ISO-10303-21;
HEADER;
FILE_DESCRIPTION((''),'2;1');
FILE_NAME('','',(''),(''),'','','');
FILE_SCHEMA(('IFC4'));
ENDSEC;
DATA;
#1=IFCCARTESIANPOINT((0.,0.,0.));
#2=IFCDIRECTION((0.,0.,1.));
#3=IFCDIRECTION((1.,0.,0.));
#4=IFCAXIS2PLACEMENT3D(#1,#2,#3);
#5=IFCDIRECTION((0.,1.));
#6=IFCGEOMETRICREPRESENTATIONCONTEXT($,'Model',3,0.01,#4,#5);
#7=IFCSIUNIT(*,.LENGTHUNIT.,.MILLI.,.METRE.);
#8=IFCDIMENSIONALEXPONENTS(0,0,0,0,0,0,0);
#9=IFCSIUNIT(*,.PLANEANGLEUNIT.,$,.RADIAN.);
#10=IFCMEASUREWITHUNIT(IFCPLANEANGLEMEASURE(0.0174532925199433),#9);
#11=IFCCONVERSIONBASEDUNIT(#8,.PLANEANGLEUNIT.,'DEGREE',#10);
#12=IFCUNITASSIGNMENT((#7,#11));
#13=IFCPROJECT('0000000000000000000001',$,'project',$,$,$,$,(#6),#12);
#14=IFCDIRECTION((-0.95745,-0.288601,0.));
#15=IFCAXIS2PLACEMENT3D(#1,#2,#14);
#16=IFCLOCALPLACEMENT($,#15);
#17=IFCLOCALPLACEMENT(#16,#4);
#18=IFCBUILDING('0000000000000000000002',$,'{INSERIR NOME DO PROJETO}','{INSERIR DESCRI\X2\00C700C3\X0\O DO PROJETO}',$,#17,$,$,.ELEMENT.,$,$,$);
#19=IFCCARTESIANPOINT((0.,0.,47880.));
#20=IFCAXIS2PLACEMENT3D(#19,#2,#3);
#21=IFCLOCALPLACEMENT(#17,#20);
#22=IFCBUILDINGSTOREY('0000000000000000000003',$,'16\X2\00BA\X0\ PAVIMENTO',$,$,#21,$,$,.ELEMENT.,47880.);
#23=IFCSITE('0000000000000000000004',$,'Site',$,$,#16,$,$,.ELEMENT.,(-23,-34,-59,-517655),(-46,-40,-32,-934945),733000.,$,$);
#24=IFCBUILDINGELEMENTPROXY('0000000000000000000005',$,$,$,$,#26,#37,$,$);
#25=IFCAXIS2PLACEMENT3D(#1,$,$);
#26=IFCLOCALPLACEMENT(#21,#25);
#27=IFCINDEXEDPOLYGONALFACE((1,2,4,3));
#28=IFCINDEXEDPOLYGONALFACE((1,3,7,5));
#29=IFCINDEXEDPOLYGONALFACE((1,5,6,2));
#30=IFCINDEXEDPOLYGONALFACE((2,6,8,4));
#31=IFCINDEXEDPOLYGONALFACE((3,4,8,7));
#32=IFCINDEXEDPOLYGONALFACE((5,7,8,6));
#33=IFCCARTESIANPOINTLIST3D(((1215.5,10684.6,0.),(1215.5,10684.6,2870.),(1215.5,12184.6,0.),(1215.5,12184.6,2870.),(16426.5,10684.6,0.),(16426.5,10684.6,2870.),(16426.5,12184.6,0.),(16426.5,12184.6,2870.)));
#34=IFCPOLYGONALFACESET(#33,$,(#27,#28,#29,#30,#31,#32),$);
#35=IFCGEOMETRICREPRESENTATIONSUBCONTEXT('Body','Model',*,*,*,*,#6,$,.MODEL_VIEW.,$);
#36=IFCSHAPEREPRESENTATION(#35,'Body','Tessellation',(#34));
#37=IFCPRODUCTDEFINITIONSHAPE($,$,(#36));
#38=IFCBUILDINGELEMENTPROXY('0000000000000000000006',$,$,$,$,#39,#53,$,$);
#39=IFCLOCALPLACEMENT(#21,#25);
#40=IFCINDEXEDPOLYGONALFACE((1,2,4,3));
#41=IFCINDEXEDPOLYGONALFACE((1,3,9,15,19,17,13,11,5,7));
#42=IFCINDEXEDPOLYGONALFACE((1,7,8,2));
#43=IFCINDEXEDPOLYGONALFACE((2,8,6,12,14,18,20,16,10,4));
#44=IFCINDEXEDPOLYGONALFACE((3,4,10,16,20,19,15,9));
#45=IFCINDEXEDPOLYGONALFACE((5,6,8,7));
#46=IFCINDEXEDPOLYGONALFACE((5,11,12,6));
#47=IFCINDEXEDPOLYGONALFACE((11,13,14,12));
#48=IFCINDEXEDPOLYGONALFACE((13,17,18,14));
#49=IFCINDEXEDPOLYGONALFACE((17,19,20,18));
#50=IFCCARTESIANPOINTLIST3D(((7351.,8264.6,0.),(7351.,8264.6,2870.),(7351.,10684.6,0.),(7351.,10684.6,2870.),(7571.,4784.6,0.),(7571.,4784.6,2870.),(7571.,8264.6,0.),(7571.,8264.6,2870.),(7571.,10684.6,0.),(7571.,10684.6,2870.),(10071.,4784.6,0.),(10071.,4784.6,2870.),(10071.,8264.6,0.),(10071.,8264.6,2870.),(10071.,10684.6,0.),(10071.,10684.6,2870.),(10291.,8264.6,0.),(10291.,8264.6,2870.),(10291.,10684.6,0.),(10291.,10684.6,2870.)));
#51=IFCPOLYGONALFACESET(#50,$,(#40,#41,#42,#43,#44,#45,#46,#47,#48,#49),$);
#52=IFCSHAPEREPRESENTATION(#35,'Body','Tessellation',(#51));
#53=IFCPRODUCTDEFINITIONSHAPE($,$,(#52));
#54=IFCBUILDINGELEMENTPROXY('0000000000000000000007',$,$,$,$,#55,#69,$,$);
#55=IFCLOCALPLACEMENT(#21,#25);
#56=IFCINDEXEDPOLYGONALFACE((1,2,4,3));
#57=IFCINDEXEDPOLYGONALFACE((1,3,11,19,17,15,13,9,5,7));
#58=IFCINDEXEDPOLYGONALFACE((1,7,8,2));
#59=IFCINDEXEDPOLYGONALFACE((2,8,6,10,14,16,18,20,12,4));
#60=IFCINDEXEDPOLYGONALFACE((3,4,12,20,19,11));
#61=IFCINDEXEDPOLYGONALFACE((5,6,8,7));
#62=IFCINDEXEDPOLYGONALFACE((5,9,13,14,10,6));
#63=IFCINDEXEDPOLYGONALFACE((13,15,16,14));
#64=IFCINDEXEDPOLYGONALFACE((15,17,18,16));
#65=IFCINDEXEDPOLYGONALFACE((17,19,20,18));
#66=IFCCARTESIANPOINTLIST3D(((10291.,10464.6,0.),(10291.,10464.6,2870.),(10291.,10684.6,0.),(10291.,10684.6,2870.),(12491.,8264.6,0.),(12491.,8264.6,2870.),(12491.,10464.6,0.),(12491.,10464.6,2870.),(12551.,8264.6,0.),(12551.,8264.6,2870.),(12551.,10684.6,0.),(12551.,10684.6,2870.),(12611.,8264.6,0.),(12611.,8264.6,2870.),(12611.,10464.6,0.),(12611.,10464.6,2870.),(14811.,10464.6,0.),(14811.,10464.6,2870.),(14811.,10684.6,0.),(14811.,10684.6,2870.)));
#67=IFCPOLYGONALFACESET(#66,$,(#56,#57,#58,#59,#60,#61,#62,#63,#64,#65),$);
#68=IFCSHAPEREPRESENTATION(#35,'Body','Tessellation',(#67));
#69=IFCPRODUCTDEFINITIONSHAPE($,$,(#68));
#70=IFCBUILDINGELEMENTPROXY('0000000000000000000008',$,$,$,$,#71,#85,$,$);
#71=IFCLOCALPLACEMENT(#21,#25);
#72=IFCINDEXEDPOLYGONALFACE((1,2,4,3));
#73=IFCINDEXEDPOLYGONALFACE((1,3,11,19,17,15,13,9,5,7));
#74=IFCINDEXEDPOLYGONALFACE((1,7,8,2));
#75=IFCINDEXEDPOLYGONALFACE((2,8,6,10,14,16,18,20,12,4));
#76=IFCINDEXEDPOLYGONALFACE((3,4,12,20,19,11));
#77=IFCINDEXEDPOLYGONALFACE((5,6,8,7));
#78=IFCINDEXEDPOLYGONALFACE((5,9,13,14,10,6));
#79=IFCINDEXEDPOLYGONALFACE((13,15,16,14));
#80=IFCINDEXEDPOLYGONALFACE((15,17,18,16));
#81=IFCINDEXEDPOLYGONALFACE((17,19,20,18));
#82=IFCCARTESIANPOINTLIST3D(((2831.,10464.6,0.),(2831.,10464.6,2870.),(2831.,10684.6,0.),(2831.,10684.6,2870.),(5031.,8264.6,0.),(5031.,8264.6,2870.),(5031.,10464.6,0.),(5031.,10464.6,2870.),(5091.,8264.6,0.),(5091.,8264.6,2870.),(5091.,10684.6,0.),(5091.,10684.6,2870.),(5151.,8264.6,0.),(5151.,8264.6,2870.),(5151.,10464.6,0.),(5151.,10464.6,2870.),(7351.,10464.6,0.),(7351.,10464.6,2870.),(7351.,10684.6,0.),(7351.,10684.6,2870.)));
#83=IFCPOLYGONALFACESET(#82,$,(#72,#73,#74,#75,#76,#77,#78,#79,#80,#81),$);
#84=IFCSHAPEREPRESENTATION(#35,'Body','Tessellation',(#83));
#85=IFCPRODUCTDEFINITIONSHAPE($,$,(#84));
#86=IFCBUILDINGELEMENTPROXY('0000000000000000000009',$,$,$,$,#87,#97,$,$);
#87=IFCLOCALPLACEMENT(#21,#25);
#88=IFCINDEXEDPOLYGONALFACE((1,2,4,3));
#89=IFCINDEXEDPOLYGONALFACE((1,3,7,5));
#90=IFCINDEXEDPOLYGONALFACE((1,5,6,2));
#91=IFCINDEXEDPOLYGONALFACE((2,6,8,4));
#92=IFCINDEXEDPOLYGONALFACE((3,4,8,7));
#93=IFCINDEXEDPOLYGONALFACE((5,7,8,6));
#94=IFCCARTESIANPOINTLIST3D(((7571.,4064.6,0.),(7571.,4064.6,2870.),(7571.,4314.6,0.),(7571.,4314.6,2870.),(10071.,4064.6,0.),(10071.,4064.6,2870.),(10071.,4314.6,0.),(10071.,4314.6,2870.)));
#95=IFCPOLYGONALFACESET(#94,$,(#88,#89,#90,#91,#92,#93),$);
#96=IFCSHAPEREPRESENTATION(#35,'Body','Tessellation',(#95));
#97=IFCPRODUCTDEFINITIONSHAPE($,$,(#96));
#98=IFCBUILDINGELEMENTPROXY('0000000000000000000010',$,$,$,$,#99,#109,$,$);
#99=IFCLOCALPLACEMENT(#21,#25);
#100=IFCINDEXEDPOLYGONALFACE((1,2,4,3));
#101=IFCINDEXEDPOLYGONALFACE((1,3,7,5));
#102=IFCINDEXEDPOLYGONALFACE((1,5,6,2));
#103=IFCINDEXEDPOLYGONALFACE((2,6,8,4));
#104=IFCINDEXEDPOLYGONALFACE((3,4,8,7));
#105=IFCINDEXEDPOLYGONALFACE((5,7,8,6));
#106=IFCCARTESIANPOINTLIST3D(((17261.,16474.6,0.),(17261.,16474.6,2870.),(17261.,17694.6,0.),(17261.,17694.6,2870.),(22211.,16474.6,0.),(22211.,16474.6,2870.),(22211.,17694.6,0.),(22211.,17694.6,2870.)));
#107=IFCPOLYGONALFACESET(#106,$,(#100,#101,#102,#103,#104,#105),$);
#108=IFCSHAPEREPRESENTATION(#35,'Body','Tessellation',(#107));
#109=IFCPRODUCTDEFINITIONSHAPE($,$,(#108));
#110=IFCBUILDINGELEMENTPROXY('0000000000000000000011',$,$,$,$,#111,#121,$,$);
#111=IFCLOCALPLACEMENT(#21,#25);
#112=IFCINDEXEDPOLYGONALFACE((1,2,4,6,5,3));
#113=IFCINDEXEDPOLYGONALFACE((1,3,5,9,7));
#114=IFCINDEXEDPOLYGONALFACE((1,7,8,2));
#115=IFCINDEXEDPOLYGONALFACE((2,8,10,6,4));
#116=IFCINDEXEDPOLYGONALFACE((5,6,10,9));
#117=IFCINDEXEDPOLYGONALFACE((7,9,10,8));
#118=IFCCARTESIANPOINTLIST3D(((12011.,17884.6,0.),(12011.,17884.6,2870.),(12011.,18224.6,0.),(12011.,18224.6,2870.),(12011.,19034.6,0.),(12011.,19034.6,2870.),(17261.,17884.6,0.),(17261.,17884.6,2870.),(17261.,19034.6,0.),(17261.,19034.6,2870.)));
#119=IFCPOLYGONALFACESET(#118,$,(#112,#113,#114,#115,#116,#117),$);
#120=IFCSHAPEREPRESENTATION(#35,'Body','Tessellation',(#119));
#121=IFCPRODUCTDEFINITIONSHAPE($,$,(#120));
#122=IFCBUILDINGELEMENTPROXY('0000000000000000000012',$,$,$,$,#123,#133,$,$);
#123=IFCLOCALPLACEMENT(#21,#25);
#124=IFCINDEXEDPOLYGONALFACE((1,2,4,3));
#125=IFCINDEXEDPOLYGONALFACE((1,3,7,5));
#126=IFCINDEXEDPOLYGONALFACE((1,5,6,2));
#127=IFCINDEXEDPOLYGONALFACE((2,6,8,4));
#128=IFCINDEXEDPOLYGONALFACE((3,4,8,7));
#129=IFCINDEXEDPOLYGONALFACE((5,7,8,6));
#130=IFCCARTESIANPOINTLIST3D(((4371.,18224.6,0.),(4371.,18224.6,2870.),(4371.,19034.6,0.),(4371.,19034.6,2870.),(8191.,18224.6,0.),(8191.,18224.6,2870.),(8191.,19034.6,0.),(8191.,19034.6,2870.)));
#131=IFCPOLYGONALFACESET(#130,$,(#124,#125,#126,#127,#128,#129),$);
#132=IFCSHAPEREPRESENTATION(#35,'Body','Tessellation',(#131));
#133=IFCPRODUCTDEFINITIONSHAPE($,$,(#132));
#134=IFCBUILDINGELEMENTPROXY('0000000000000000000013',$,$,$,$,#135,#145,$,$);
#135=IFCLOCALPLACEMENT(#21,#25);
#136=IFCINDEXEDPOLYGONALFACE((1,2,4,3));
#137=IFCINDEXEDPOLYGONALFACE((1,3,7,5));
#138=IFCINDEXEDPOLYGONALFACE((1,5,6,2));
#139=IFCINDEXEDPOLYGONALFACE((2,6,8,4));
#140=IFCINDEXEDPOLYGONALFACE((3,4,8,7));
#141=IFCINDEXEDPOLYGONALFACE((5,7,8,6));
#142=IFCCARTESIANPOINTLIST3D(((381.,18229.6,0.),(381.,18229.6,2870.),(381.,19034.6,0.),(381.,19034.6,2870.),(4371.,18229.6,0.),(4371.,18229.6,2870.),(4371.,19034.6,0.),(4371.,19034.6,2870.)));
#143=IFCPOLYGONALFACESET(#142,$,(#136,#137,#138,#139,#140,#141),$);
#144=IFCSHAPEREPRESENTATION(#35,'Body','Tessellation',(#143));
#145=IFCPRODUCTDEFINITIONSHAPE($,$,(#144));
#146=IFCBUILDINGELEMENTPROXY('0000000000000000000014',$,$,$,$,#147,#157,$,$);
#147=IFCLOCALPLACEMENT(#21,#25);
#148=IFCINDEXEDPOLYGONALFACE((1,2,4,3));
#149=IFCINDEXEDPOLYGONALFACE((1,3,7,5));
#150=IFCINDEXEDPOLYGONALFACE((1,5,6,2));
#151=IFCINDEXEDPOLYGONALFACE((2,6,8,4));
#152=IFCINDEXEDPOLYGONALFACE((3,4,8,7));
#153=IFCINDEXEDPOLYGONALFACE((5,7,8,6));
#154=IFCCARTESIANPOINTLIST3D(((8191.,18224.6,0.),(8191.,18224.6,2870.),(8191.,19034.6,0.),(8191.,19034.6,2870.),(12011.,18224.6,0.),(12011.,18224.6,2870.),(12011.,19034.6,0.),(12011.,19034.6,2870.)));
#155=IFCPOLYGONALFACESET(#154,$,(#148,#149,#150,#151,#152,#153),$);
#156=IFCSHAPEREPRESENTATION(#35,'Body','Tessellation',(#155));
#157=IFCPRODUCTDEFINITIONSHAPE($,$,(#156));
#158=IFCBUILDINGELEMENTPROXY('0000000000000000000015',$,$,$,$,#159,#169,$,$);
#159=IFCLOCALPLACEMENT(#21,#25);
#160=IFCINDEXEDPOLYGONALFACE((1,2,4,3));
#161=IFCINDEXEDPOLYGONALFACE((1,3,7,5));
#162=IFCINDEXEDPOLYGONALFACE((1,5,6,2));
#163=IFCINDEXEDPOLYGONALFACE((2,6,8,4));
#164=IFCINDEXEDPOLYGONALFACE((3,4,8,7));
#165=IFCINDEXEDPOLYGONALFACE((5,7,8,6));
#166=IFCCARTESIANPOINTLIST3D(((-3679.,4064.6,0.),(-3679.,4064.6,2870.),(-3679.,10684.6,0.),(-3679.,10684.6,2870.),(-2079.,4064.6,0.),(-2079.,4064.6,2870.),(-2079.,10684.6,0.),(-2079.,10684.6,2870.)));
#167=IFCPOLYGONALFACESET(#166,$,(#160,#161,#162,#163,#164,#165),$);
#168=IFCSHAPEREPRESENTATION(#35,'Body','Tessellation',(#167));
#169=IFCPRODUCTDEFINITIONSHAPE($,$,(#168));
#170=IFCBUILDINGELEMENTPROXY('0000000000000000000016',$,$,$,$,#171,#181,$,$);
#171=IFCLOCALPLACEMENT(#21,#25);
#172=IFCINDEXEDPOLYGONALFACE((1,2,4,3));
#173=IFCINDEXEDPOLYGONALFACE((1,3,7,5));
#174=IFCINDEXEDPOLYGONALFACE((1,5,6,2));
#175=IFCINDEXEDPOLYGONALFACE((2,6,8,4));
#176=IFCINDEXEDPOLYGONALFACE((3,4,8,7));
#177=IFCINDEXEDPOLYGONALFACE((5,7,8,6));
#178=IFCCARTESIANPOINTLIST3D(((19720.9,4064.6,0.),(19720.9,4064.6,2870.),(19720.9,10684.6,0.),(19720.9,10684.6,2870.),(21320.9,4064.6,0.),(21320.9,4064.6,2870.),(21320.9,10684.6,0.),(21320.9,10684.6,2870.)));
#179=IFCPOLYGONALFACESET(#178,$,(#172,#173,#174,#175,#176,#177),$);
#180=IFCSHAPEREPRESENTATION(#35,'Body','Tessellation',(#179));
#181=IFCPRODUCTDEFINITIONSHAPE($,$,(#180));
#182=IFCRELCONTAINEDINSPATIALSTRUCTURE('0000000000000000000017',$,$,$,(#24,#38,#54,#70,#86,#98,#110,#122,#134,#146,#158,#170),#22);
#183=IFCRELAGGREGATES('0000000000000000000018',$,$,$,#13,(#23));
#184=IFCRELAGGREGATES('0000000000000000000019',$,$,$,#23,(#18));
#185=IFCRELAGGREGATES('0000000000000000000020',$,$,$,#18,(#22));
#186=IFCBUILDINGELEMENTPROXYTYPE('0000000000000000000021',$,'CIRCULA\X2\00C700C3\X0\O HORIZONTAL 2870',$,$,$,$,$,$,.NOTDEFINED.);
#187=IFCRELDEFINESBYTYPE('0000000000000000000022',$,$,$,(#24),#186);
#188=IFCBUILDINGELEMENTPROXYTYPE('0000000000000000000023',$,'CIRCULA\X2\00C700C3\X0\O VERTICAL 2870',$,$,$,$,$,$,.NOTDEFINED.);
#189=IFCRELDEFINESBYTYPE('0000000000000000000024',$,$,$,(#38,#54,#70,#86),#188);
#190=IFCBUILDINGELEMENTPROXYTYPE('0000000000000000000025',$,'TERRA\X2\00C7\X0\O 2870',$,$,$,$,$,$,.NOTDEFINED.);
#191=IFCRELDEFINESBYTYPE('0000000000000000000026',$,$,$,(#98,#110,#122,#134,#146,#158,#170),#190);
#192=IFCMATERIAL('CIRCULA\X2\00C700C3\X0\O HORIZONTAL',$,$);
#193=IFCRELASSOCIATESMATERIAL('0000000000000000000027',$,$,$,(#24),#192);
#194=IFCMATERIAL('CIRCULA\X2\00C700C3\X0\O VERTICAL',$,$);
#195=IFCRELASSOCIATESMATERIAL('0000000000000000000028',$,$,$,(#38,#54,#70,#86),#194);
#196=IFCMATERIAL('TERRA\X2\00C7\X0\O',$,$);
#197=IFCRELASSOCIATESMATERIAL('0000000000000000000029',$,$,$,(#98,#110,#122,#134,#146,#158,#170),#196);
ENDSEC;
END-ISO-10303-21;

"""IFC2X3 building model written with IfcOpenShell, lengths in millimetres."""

from ifc_helpers import new_model, entity, si_unit, converted_unit, direction, frame, origin_with_axes, place, context, subcontext, project, spatial, polyline, outline, extrude, material, type_object, element, save


model = new_model("IFC2X3")

# Units and contexts
model_context = context("Model", 3, precision=0.01, world=origin_with_axes(), true_north=direction((0.0, 1.0)))
body_context = subcontext(model_context, "Body", "Model", "MODEL_VIEW")
ifc_project = project(units=[si_unit("LENGTHUNIT", "METRE", prefix="MILLI"), converted_unit("PLANEANGLEUNIT", "DEGREE", entity("IfcPlaneAngleMeasure", 0.0174532925199433), si_unit("PLANEANGLEUNIT", "RADIAN"), dimensions=[0, 0, 0, 0, 0, 0, 0])], contexts=[model_context])

# Site, building, storey
site_placement = place(None, frame((0.0, 0.0, 0.0), z_axis=(0.0, 0.0, 1.0), x_axis=(-0.95745, -0.288601, 0.0)))
site = spatial("IfcSite", under=ifc_project, at=site_placement, Name="Site", CompositionType="ELEMENT", RefLatitude=(-23, -34, -59, -517655), RefLongitude=(-46, -40, -32, -934945), RefElevation=733000.0)
building_placement = place(site_placement, origin_with_axes())
building = spatial("IfcBuilding", under=site, at=building_placement, Name="{INSERIR NOME DO PROJETO}", Description="{INSERIR DESCRIÇÃO DO PROJETO}", CompositionType="ELEMENT")
storey_placement = place(building_placement, frame((0.0, 0.0, 47880.0), z_axis=(0.0, 0.0, 1.0), x_axis=(1.0, 0.0, 0.0)))
storey = spatial("IfcBuildingStorey", under=building, at=storey_placement, Name="16º PAVIMENTO", CompositionType="ELEMENT", Elevation=47880.0)

# Building element proxies
ifc_material_1 = material(Name="CIRCULAÇÃO HORIZONTAL")
building_element_proxy_type_1 = type_object("IfcBuildingElementProxyType", Name="CIRCULAÇÃO HORIZONTAL 2870", PredefinedType="NOTDEFINED")
proxy_1_placement = place(storey_placement, frame((1215.5, 10684.6, 0.0), z_axis=(0.0, 0.0, 1.0), x_axis=(1.0, 0.0, 0.0)))
element("IfcBuildingElementProxy", 1, at=proxy_1_placement, inside=storey, type_object=building_element_proxy_type_1, material=ifc_material_1, context=body_context, shape_type="SweptSolid", body=[
    extrude(outline(polyline([(0.0, 0.0), (15211.0, 0.0), (15211.0, 1500.0), (0.0, 1500.0), (0.0, 0.0)])), origin_with_axes(), (0.0, 0.0, 1.0), 2870.0),
])
ifc_material_2 = material(Name="CIRCULAÇÃO VERTICAL")
building_element_proxy_type_2 = type_object("IfcBuildingElementProxyType", Name="CIRCULAÇÃO VERTICAL 2870", PredefinedType="NOTDEFINED")
proxy_2_placement = place(storey_placement, frame((7351.0, 10684.6, 0.0), z_axis=(0.0, 0.0, 1.0), x_axis=(1.0, 0.0, 0.0)))
element("IfcBuildingElementProxy", 2, at=proxy_2_placement, inside=storey, type_object=building_element_proxy_type_2, material=ifc_material_2, context=body_context, shape_type="SweptSolid", body=[
    extrude(outline(polyline([(0.0, 0.0), (0.0, -2420.0), (220.0, -2420.0), (220.0, -5900.0), (2720.0, -5900.0), (2720.0, -2420.0), (2940.0, -2420.0), (2940.0, 0.0), (2720.0, 0.0), (220.0, 0.0), (0.0, 0.0)])), origin_with_axes(), (0.0, 0.0, 1.0), 2870.0),
])
proxy_3_placement = place(storey_placement, frame((10291.0, 10684.6, 0.0), z_axis=(0.0, 0.0, 1.0), x_axis=(1.0, 0.0, 0.0)))
element("IfcBuildingElementProxy", 3, at=proxy_3_placement, inside=storey, type_object=building_element_proxy_type_2, material=ifc_material_2, context=body_context, shape_type="SweptSolid", body=[
    extrude(outline(polyline([(0.0, 0.0), (0.0, -220.0), (2200.0, -220.0), (2200.0, -2420.0), (2260.0, -2420.0), (2320.0, -2420.0), (2320.0, -220.0), (4520.0, -220.0), (4520.0, 0.0), (2260.0, 0.0), (0.0, 0.0)])), origin_with_axes(), (0.0, 0.0, 1.0), 2870.0),
])
proxy_4_placement = place(storey_placement, frame((5091.0, 10684.6, 0.0), z_axis=(0.0, 0.0, 1.0), x_axis=(1.0, 0.0, 0.0)))
element("IfcBuildingElementProxy", 4, at=proxy_4_placement, inside=storey, type_object=building_element_proxy_type_2, material=ifc_material_2, context=body_context, shape_type="SweptSolid", body=[
    extrude(outline(polyline([(0.0, 0.0), (-2260.0, 0.0), (-2260.0, -220.0), (-60.0, -220.0), (-60.0, -2420.0), (0.0, -2420.0), (60.0, -2420.0), (60.0, -220.0), (2260.0, -220.0), (2260.0, 0.0), (0.0, 0.0)])), origin_with_axes(), (0.0, 0.0, 1.0), 2870.0),
])
proxy_5_placement = place(storey_placement, frame((7571.0, 4064.6, 0.0), z_axis=(0.0, 0.0, 1.0), x_axis=(1.0, 0.0, 0.0)))
element("IfcBuildingElementProxy", 5, at=proxy_5_placement, inside=storey, type_object=building_element_proxy_type_2, material=ifc_material_2, context=body_context, shape_type="SweptSolid", body=[
    extrude(outline(polyline([(0.0, 0.0), (2500.0, 0.0), (2500.0, 250.0), (0.0, 250.0), (0.0, 0.0)])), origin_with_axes(), (0.0, 0.0, 1.0), 2870.0),
])
ifc_material_3 = material(Name="TERRAÇO")
building_element_proxy_type_3 = type_object("IfcBuildingElementProxyType", Name="TERRAÇO 2870", PredefinedType="NOTDEFINED")
proxy_6_placement = place(storey_placement, frame((17261.0, 16474.6, 0.0), z_axis=(0.0, 0.0, 1.0), x_axis=(1.0, 0.0, 0.0)))
element("IfcBuildingElementProxy", 6, at=proxy_6_placement, inside=storey, type_object=building_element_proxy_type_3, material=ifc_material_3, context=body_context, shape_type="SweptSolid", body=[
    extrude(outline(polyline([(0.0, 0.0), (4950.0, 0.0), (4950.0, 1220.0), (0.0, 1220.0), (0.0, 0.0)])), origin_with_axes(), (0.0, 0.0, 1.0), 2870.0),
])
proxy_7_placement = place(storey_placement, frame((12011.0, 19034.6, 0.0), z_axis=(0.0, 0.0, 1.0), x_axis=(1.0, 0.0, 0.0)))
element("IfcBuildingElementProxy", 7, at=proxy_7_placement, inside=storey, type_object=building_element_proxy_type_3, material=ifc_material_3, context=body_context, shape_type="SweptSolid", body=[
    extrude(outline(polyline([(0.0, 0.0), (0.0, -810.0), (0.0, -1150.0), (5250.0, -1150.0), (5250.0, 0.0), (0.0, 0.0)])), origin_with_axes(), (0.0, 0.0, 1.0), 2870.0),
])
proxy_8_placement = place(storey_placement, frame((4371.0, 18224.6, 0.0), z_axis=(0.0, 0.0, 1.0), x_axis=(1.0, 0.0, 0.0)))
element("IfcBuildingElementProxy", 8, at=proxy_8_placement, inside=storey, type_object=building_element_proxy_type_3, material=ifc_material_3, context=body_context, shape_type="SweptSolid", body=[
    extrude(outline(polyline([(0.0, 0.0), (3820.0, 0.0), (3820.0, 810.0), (0.0, 810.0), (0.0, 0.0)])), origin_with_axes(), (0.0, 0.0, 1.0), 2870.0),
])
proxy_9_placement = place(storey_placement, frame((381.0, 19034.6, 0.0), z_axis=(0.0, 0.0, 1.0), x_axis=(1.0, 0.0, 0.0)))
element("IfcBuildingElementProxy", 9, at=proxy_9_placement, inside=storey, type_object=building_element_proxy_type_3, material=ifc_material_3, context=body_context, shape_type="SweptSolid", body=[
    extrude(outline(polyline([(0.0, 0.0), (0.0, -805.0), (3990.0, -805.0), (3990.0, 0.0), (0.0, 0.0)])), origin_with_axes(), (0.0, 0.0, 1.0), 2870.0),
])
proxy_10_placement = place(storey_placement, frame((8191.0, 18224.6, 0.0), z_axis=(0.0, 0.0, 1.0), x_axis=(1.0, 0.0, 0.0)))
element("IfcBuildingElementProxy", 10, at=proxy_10_placement, inside=storey, type_object=building_element_proxy_type_3, material=ifc_material_3, context=body_context, shape_type="SweptSolid", body=[
    extrude(outline(polyline([(0.0, 0.0), (3820.0, 0.0), (3820.0, 810.0), (0.0, 810.0), (0.0, 0.0)])), origin_with_axes(), (0.0, 0.0, 1.0), 2870.0),
])
proxy_11_placement = place(storey_placement, frame((-3679.0, 4064.6, 0.0), z_axis=(0.0, 0.0, 1.0), x_axis=(1.0, 0.0, 0.0)))
element("IfcBuildingElementProxy", 11, at=proxy_11_placement, inside=storey, type_object=building_element_proxy_type_3, material=ifc_material_3, context=body_context, shape_type="SweptSolid", body=[
    extrude(outline(polyline([(0.0, 0.0), (1600.0, 0.0), (1600.0, 6620.0), (0.0, 6620.0), (0.0, 0.0)])), origin_with_axes(), (0.0, 0.0, 1.0), 2870.0),
])
proxy_12_placement = place(storey_placement, frame((21320.9, 4064.6, 0.0), z_axis=(0.0, 0.0, 1.0), x_axis=(1.0, 0.0, 0.0)))
element("IfcBuildingElementProxy", 12, at=proxy_12_placement, inside=storey, type_object=building_element_proxy_type_3, material=ifc_material_3, context=body_context, shape_type="SweptSolid", body=[
    extrude(outline(polyline([(0.0, 0.0), (0.0, 6620.0), (-1600.0, 6620.0), (-1600.0, 0.0), (0.0, 0.0)])), origin_with_axes(), (0.0, 0.0, 1.0), 2870.0),
])

save(model, "model.ifc")
